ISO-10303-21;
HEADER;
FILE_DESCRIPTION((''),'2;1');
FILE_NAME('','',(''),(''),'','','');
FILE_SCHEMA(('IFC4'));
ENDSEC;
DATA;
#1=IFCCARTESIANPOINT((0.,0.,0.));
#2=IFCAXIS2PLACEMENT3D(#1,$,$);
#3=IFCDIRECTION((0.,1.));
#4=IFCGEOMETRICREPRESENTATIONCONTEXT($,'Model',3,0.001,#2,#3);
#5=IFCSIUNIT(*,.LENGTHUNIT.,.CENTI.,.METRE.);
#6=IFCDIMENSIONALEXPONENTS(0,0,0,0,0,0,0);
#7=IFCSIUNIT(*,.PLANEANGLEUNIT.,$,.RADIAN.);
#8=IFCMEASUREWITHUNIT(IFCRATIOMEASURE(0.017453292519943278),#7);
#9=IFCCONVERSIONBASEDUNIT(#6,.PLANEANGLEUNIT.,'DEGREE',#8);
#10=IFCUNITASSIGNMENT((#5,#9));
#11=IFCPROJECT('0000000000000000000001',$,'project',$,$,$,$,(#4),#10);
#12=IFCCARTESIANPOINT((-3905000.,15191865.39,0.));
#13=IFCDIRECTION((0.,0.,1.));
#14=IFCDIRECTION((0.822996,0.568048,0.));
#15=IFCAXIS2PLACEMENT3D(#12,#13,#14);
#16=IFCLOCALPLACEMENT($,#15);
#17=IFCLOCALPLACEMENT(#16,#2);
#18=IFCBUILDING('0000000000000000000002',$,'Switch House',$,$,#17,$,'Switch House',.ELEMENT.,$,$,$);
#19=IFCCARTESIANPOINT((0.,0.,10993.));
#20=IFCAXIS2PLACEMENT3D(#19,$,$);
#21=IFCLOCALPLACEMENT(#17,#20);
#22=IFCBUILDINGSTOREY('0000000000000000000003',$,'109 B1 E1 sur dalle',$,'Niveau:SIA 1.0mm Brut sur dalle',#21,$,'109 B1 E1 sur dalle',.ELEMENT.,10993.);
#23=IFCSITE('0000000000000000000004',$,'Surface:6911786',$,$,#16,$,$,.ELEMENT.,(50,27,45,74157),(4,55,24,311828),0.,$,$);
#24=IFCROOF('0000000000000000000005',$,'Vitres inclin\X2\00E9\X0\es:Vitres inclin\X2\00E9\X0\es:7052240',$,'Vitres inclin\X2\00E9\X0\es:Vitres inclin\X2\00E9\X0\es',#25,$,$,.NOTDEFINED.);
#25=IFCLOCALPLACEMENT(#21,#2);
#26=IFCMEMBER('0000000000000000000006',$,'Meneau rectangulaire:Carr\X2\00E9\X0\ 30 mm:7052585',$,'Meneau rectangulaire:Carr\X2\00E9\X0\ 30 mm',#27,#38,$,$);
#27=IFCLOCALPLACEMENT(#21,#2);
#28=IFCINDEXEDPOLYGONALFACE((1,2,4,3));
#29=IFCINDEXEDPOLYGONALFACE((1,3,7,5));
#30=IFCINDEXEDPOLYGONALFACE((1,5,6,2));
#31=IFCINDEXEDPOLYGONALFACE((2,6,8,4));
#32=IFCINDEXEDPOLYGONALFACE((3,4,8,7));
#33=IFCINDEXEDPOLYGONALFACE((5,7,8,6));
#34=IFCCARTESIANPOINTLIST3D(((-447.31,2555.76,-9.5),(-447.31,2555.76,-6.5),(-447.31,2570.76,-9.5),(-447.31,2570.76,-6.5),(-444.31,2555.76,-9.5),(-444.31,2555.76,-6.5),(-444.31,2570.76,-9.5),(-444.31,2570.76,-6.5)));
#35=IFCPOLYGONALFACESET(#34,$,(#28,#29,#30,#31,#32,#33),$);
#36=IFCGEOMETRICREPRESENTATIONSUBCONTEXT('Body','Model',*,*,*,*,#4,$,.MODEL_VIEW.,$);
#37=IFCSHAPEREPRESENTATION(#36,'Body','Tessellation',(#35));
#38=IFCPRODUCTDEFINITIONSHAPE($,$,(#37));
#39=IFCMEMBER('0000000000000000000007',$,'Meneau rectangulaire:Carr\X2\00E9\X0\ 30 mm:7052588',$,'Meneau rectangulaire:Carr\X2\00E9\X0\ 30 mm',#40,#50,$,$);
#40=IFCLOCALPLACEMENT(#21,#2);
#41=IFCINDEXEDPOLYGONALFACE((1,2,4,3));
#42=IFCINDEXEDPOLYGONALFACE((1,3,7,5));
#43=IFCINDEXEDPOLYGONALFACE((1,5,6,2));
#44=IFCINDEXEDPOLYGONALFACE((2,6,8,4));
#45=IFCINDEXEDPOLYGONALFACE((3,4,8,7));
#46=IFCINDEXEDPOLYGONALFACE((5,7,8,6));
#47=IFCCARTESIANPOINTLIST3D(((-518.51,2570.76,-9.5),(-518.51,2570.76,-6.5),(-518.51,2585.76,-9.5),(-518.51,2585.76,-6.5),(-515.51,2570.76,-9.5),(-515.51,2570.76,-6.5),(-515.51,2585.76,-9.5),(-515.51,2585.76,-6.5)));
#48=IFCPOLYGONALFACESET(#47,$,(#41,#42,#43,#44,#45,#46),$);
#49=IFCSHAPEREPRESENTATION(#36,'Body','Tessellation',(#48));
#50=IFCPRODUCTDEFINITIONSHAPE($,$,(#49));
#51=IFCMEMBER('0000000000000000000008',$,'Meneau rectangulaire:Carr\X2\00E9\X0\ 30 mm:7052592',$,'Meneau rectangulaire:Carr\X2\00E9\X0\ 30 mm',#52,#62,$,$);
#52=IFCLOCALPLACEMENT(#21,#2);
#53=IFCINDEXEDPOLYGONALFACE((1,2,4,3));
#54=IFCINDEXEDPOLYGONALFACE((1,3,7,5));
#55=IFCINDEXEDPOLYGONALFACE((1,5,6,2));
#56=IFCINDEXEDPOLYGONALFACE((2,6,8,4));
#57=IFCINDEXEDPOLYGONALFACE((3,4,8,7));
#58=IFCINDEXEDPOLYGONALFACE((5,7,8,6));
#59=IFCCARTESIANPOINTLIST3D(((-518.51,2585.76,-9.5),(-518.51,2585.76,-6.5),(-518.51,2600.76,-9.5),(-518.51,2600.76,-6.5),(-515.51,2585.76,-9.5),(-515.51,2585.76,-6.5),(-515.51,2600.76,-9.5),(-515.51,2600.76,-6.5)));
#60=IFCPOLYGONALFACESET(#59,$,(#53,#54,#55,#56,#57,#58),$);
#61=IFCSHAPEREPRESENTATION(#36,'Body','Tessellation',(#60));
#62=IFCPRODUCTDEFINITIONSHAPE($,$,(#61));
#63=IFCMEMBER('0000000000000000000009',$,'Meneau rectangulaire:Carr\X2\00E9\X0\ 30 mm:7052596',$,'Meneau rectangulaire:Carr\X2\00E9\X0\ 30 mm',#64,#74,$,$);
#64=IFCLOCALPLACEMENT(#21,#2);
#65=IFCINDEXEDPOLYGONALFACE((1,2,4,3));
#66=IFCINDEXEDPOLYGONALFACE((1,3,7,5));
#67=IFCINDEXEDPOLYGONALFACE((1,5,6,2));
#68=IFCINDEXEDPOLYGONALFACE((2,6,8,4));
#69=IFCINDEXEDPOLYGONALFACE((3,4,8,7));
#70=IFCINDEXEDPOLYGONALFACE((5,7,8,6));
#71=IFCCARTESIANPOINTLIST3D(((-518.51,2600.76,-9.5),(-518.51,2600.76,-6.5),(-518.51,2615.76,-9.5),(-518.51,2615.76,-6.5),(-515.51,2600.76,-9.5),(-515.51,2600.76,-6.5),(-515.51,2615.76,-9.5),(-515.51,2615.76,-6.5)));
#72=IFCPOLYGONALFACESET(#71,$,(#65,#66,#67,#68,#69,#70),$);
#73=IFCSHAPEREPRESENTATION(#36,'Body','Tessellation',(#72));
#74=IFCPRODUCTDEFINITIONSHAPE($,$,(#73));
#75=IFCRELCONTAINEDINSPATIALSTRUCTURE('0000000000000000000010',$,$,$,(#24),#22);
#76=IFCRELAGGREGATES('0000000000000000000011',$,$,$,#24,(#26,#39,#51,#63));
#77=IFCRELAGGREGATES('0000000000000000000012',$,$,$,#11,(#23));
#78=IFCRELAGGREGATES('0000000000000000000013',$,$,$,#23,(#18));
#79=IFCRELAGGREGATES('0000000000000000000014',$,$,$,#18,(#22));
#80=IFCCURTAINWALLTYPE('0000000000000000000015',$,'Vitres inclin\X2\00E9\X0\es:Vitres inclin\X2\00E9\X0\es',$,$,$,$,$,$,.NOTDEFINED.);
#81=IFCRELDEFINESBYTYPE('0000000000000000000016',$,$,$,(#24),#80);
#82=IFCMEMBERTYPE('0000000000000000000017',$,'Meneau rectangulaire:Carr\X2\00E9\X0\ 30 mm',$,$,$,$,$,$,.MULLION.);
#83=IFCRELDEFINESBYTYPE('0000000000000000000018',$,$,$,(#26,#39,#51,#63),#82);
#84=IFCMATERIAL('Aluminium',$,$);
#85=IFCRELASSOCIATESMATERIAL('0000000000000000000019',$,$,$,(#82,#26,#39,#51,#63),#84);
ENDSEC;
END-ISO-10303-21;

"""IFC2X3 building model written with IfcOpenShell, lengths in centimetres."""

from ifc_helpers import new_model, entity, si_unit, converted_unit, direction, frame, origin, origin_2d_with_axis, place, context, subcontext, project, spatial, rectangle, extrude, source, transform, mapped, material, type_object, type_shapes, element, aggregate, save


model = new_model("IFC2X3")

# Units and contexts
model_context = context("Model", 3, precision=0.001, world=origin(), true_north=direction((0.0, 1.0)))
body_context = subcontext(model_context, "Body", "Model", "MODEL_VIEW")
ifc_project = project(units=[si_unit("LENGTHUNIT", "METRE", prefix="CENTI"), converted_unit("PLANEANGLEUNIT", "DEGREE", entity("IfcRatioMeasure", 0.017453292519943278), si_unit("PLANEANGLEUNIT", "RADIAN"), dimensions=[0, 0, 0, 0, 0, 0, 0])], contexts=[model_context])

# Site, building, storey
site_placement = place(None, frame((-3905000.0, 15191865.39, 0.0), z_axis=(0.0, 0.0, 1.0), x_axis=(0.822996, 0.568048, 0.0)))
site = spatial("IfcSite", under=ifc_project, at=site_placement, Name="Surface:6911786", CompositionType="ELEMENT", RefLatitude=(50, 27, 45, 74157), RefLongitude=(4, 55, 24, 311828), RefElevation=0.0)
building_placement = place(site_placement, origin())
building = spatial("IfcBuilding", under=site, at=building_placement, Name="Switch House", LongName="Switch House", CompositionType="ELEMENT")
storey_placement = place(building_placement, frame((0.0, 0.0, 10993.0)))
storey = spatial("IfcBuildingStorey", under=building, at=storey_placement, Name="109 B1 E1 sur dalle", ObjectType="Niveau:SIA 1.0mm Brut sur dalle", LongName="109 B1 E1 sur dalle", CompositionType="ELEMENT", Elevation=10993.0)

# Roof, members
curtain_wall_type = type_object("IfcCurtainWallType", Name="Vitres inclinées:Vitres inclinées", PredefinedType="NOTDEFINED")
roof_placement = place(storey_placement, frame((0.0, 0.0, -10993.0)))
roof = element("IfcRoof", 1, at=roof_placement, inside=storey, type_object=curtain_wall_type, Name="Vitres inclinées:Vitres inclinées:7052240", ObjectType="Vitres inclinées:Vitres inclinées", ShapeType="NOTDEFINED")
ifc_material = material(Name="Aluminium")
member_type_1 = type_object("IfcMemberType", Name="Meneau rectangulaire:Carré 30 mm", PredefinedType="MULLION", material=ifc_material)
shared_shape_1 = source(origin(), body_context, "Body", "SweptSolid", [
    extrude(rectangle(XDim=3.0, YDim=3.0, at=origin_2d_with_axis()), frame((0.0, 0.0, -15.0), z_axis=(0.0, 0.0, 1.0), x_axis=(0.0, -1.0, 0.0)), (0.0, 0.0, 1.0), 15.0),
])
type_shapes(member_type_1, [shared_shape_1])
member_1_placement = place(roof_placement, frame((-445.81, 2570.76, 10985.0), z_axis=(0.0, 1.0, 0.0), x_axis=(1.0, 0.0, 0.0)))
member_1 = element("IfcMember", 2, at=member_1_placement, type_object=member_type_1, material=ifc_material, Name="Meneau rectangulaire:Carré 30 mm:7052585", ObjectType="Meneau rectangulaire:Carré 30 mm", context=body_context, shape_type="MappedRepresentation", body=[
    mapped(shared_shape_1, transform((0.0, 0.0, 0.0), scale=1.0)),
])
member_2_placement = place(roof_placement, frame((-517.01, 2585.76, 10985.0), z_axis=(0.0, 1.0, 0.0), x_axis=(1.0, 0.0, 0.0)))
member_2 = element("IfcMember", 3, at=member_2_placement, type_object=member_type_1, material=ifc_material, Name="Meneau rectangulaire:Carré 30 mm:7052588", ObjectType="Meneau rectangulaire:Carré 30 mm", context=body_context, shape_type="MappedRepresentation", body=[
    mapped(shared_shape_1, transform((0.0, 0.0, 0.0), scale=1.0)),
])
member_3_placement = place(roof_placement, frame((-517.01, 2600.76, 10985.0), z_axis=(0.0, 1.0, 0.0), x_axis=(1.0, 0.0, 0.0)))
member_3 = element("IfcMember", 4, at=member_3_placement, type_object=member_type_1, material=ifc_material, Name="Meneau rectangulaire:Carré 30 mm:7052592", ObjectType="Meneau rectangulaire:Carré 30 mm", context=body_context, shape_type="MappedRepresentation", body=[
    mapped(shared_shape_1, transform((0.0, 0.0, 0.0), scale=1.0)),
])
member_4_placement = place(roof_placement, frame((-517.01, 2615.76, 10985.0), z_axis=(0.0, 1.0, 0.0), x_axis=(1.0, 0.0, 0.0)))
member_4 = element("IfcMember", 5, at=member_4_placement, type_object=member_type_1, material=ifc_material, Name="Meneau rectangulaire:Carré 30 mm:7052596", ObjectType="Meneau rectangulaire:Carré 30 mm", context=body_context, shape_type="MappedRepresentation", body=[
    mapped(shared_shape_1, transform((0.0, 0.0, 0.0), scale=1.0)),
])
aggregate(roof, [member_1, member_2, member_3, member_4])

save(model, "model.ifc")
